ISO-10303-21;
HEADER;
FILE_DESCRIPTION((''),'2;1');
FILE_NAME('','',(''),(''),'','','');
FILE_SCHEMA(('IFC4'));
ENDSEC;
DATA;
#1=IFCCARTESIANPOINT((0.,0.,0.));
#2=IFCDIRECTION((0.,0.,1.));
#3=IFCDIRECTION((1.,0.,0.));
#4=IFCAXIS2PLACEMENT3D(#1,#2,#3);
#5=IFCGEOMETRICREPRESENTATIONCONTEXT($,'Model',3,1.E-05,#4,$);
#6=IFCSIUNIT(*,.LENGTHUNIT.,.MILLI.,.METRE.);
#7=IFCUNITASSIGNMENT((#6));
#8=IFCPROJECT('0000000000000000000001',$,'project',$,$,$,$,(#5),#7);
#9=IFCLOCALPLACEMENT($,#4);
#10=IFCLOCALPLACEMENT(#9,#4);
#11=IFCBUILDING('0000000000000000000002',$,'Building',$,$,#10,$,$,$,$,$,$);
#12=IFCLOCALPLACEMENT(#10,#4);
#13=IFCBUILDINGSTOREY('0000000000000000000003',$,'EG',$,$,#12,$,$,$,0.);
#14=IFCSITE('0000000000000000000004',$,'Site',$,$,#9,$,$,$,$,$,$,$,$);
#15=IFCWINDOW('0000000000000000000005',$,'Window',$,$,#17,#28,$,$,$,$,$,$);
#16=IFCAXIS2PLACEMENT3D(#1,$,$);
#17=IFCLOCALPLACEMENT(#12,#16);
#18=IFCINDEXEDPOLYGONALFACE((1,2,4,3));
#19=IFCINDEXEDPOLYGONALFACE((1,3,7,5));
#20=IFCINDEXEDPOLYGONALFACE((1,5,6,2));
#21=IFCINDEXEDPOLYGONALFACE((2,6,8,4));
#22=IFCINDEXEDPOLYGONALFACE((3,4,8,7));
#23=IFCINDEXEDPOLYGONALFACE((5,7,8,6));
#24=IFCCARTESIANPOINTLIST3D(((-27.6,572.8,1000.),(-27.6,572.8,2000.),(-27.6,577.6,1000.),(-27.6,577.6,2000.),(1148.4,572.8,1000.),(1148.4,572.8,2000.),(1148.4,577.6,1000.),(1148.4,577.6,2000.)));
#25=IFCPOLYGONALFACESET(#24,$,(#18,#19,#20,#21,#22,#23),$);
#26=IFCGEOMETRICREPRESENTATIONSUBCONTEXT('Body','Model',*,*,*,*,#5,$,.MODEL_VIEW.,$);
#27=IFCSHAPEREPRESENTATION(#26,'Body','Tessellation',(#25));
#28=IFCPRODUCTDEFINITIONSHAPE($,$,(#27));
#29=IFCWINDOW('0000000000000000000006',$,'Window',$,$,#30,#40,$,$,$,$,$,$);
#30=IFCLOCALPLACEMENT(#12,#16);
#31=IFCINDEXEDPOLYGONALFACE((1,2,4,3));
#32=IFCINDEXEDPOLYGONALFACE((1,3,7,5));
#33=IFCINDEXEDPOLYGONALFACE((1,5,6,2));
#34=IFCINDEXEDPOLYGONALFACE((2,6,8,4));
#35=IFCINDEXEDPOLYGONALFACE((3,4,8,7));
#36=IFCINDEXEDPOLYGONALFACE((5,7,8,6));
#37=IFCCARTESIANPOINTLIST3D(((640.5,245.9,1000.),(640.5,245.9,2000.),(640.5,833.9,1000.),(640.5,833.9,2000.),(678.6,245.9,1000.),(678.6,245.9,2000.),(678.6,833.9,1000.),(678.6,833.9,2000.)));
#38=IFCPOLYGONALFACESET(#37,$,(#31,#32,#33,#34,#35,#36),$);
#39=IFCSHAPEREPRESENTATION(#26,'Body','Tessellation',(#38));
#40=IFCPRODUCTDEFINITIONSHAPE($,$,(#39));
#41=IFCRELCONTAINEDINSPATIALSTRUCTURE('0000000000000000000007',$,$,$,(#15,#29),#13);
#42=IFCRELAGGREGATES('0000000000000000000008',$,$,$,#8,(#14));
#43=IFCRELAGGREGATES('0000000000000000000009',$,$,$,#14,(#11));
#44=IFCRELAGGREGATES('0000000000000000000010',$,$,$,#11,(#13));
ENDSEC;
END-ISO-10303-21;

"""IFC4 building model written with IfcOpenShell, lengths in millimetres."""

from ifc_helpers import new_model, si_unit, frame, origin_with_axes, place, context, subcontext, project, spatial, rectangle, extrude, element, save


model = new_model("IFC4")

# Units and contexts
model_context = context("Model", 3, precision=1e-05, world=origin_with_axes())
body_context = subcontext(model_context, "Body", "Model", "MODEL_VIEW")
ifc_project = project(units=[si_unit("LENGTHUNIT", "METRE", prefix="MILLI")], contexts=[model_context])

# Site, building, storey
site_placement = place(None, origin_with_axes())
site = spatial("IfcSite", under=ifc_project, at=site_placement, Name="Site")
building_placement = place(site_placement, origin_with_axes())
building = spatial("IfcBuilding", under=site, at=building_placement, Name="Building")
storey_placement = place(building_placement, origin_with_axes())
storey = spatial("IfcBuildingStorey", under=building, at=storey_placement, Name="EG", Elevation=0.0)

# Windows
window_1_placement = place(storey_placement, origin_with_axes())
element("IfcWindow", 1, at=window_1_placement, inside=storey, Name="Window", context=body_context, shape_type="SweptSolid", body=[
    extrude(rectangle(XDim=1176.0, YDim=4.8), frame((560.4, 575.2, 1000.0), z_axis=(0.0, 0.0, 1.0), x_axis=(1.0, 0.0, 0.0)), (0.0, 0.0, 1.0), 1000.0),
])
window_2_placement = place(storey_placement, origin_with_axes())
element("IfcWindow", 2, at=window_2_placement, inside=storey, Name="Window", context=body_context, shape_type="SweptSolid", body=[
    extrude(rectangle(XDim=588.0, YDim=38.1), frame((659.6, 539.9, 1000.0), z_axis=(0.0, 0.0, 1.0), x_axis=(0.0, 1.0, 0.0)), (0.0, 0.0, 1.0), 1000.0),
])

save(model, "model.ifc")
